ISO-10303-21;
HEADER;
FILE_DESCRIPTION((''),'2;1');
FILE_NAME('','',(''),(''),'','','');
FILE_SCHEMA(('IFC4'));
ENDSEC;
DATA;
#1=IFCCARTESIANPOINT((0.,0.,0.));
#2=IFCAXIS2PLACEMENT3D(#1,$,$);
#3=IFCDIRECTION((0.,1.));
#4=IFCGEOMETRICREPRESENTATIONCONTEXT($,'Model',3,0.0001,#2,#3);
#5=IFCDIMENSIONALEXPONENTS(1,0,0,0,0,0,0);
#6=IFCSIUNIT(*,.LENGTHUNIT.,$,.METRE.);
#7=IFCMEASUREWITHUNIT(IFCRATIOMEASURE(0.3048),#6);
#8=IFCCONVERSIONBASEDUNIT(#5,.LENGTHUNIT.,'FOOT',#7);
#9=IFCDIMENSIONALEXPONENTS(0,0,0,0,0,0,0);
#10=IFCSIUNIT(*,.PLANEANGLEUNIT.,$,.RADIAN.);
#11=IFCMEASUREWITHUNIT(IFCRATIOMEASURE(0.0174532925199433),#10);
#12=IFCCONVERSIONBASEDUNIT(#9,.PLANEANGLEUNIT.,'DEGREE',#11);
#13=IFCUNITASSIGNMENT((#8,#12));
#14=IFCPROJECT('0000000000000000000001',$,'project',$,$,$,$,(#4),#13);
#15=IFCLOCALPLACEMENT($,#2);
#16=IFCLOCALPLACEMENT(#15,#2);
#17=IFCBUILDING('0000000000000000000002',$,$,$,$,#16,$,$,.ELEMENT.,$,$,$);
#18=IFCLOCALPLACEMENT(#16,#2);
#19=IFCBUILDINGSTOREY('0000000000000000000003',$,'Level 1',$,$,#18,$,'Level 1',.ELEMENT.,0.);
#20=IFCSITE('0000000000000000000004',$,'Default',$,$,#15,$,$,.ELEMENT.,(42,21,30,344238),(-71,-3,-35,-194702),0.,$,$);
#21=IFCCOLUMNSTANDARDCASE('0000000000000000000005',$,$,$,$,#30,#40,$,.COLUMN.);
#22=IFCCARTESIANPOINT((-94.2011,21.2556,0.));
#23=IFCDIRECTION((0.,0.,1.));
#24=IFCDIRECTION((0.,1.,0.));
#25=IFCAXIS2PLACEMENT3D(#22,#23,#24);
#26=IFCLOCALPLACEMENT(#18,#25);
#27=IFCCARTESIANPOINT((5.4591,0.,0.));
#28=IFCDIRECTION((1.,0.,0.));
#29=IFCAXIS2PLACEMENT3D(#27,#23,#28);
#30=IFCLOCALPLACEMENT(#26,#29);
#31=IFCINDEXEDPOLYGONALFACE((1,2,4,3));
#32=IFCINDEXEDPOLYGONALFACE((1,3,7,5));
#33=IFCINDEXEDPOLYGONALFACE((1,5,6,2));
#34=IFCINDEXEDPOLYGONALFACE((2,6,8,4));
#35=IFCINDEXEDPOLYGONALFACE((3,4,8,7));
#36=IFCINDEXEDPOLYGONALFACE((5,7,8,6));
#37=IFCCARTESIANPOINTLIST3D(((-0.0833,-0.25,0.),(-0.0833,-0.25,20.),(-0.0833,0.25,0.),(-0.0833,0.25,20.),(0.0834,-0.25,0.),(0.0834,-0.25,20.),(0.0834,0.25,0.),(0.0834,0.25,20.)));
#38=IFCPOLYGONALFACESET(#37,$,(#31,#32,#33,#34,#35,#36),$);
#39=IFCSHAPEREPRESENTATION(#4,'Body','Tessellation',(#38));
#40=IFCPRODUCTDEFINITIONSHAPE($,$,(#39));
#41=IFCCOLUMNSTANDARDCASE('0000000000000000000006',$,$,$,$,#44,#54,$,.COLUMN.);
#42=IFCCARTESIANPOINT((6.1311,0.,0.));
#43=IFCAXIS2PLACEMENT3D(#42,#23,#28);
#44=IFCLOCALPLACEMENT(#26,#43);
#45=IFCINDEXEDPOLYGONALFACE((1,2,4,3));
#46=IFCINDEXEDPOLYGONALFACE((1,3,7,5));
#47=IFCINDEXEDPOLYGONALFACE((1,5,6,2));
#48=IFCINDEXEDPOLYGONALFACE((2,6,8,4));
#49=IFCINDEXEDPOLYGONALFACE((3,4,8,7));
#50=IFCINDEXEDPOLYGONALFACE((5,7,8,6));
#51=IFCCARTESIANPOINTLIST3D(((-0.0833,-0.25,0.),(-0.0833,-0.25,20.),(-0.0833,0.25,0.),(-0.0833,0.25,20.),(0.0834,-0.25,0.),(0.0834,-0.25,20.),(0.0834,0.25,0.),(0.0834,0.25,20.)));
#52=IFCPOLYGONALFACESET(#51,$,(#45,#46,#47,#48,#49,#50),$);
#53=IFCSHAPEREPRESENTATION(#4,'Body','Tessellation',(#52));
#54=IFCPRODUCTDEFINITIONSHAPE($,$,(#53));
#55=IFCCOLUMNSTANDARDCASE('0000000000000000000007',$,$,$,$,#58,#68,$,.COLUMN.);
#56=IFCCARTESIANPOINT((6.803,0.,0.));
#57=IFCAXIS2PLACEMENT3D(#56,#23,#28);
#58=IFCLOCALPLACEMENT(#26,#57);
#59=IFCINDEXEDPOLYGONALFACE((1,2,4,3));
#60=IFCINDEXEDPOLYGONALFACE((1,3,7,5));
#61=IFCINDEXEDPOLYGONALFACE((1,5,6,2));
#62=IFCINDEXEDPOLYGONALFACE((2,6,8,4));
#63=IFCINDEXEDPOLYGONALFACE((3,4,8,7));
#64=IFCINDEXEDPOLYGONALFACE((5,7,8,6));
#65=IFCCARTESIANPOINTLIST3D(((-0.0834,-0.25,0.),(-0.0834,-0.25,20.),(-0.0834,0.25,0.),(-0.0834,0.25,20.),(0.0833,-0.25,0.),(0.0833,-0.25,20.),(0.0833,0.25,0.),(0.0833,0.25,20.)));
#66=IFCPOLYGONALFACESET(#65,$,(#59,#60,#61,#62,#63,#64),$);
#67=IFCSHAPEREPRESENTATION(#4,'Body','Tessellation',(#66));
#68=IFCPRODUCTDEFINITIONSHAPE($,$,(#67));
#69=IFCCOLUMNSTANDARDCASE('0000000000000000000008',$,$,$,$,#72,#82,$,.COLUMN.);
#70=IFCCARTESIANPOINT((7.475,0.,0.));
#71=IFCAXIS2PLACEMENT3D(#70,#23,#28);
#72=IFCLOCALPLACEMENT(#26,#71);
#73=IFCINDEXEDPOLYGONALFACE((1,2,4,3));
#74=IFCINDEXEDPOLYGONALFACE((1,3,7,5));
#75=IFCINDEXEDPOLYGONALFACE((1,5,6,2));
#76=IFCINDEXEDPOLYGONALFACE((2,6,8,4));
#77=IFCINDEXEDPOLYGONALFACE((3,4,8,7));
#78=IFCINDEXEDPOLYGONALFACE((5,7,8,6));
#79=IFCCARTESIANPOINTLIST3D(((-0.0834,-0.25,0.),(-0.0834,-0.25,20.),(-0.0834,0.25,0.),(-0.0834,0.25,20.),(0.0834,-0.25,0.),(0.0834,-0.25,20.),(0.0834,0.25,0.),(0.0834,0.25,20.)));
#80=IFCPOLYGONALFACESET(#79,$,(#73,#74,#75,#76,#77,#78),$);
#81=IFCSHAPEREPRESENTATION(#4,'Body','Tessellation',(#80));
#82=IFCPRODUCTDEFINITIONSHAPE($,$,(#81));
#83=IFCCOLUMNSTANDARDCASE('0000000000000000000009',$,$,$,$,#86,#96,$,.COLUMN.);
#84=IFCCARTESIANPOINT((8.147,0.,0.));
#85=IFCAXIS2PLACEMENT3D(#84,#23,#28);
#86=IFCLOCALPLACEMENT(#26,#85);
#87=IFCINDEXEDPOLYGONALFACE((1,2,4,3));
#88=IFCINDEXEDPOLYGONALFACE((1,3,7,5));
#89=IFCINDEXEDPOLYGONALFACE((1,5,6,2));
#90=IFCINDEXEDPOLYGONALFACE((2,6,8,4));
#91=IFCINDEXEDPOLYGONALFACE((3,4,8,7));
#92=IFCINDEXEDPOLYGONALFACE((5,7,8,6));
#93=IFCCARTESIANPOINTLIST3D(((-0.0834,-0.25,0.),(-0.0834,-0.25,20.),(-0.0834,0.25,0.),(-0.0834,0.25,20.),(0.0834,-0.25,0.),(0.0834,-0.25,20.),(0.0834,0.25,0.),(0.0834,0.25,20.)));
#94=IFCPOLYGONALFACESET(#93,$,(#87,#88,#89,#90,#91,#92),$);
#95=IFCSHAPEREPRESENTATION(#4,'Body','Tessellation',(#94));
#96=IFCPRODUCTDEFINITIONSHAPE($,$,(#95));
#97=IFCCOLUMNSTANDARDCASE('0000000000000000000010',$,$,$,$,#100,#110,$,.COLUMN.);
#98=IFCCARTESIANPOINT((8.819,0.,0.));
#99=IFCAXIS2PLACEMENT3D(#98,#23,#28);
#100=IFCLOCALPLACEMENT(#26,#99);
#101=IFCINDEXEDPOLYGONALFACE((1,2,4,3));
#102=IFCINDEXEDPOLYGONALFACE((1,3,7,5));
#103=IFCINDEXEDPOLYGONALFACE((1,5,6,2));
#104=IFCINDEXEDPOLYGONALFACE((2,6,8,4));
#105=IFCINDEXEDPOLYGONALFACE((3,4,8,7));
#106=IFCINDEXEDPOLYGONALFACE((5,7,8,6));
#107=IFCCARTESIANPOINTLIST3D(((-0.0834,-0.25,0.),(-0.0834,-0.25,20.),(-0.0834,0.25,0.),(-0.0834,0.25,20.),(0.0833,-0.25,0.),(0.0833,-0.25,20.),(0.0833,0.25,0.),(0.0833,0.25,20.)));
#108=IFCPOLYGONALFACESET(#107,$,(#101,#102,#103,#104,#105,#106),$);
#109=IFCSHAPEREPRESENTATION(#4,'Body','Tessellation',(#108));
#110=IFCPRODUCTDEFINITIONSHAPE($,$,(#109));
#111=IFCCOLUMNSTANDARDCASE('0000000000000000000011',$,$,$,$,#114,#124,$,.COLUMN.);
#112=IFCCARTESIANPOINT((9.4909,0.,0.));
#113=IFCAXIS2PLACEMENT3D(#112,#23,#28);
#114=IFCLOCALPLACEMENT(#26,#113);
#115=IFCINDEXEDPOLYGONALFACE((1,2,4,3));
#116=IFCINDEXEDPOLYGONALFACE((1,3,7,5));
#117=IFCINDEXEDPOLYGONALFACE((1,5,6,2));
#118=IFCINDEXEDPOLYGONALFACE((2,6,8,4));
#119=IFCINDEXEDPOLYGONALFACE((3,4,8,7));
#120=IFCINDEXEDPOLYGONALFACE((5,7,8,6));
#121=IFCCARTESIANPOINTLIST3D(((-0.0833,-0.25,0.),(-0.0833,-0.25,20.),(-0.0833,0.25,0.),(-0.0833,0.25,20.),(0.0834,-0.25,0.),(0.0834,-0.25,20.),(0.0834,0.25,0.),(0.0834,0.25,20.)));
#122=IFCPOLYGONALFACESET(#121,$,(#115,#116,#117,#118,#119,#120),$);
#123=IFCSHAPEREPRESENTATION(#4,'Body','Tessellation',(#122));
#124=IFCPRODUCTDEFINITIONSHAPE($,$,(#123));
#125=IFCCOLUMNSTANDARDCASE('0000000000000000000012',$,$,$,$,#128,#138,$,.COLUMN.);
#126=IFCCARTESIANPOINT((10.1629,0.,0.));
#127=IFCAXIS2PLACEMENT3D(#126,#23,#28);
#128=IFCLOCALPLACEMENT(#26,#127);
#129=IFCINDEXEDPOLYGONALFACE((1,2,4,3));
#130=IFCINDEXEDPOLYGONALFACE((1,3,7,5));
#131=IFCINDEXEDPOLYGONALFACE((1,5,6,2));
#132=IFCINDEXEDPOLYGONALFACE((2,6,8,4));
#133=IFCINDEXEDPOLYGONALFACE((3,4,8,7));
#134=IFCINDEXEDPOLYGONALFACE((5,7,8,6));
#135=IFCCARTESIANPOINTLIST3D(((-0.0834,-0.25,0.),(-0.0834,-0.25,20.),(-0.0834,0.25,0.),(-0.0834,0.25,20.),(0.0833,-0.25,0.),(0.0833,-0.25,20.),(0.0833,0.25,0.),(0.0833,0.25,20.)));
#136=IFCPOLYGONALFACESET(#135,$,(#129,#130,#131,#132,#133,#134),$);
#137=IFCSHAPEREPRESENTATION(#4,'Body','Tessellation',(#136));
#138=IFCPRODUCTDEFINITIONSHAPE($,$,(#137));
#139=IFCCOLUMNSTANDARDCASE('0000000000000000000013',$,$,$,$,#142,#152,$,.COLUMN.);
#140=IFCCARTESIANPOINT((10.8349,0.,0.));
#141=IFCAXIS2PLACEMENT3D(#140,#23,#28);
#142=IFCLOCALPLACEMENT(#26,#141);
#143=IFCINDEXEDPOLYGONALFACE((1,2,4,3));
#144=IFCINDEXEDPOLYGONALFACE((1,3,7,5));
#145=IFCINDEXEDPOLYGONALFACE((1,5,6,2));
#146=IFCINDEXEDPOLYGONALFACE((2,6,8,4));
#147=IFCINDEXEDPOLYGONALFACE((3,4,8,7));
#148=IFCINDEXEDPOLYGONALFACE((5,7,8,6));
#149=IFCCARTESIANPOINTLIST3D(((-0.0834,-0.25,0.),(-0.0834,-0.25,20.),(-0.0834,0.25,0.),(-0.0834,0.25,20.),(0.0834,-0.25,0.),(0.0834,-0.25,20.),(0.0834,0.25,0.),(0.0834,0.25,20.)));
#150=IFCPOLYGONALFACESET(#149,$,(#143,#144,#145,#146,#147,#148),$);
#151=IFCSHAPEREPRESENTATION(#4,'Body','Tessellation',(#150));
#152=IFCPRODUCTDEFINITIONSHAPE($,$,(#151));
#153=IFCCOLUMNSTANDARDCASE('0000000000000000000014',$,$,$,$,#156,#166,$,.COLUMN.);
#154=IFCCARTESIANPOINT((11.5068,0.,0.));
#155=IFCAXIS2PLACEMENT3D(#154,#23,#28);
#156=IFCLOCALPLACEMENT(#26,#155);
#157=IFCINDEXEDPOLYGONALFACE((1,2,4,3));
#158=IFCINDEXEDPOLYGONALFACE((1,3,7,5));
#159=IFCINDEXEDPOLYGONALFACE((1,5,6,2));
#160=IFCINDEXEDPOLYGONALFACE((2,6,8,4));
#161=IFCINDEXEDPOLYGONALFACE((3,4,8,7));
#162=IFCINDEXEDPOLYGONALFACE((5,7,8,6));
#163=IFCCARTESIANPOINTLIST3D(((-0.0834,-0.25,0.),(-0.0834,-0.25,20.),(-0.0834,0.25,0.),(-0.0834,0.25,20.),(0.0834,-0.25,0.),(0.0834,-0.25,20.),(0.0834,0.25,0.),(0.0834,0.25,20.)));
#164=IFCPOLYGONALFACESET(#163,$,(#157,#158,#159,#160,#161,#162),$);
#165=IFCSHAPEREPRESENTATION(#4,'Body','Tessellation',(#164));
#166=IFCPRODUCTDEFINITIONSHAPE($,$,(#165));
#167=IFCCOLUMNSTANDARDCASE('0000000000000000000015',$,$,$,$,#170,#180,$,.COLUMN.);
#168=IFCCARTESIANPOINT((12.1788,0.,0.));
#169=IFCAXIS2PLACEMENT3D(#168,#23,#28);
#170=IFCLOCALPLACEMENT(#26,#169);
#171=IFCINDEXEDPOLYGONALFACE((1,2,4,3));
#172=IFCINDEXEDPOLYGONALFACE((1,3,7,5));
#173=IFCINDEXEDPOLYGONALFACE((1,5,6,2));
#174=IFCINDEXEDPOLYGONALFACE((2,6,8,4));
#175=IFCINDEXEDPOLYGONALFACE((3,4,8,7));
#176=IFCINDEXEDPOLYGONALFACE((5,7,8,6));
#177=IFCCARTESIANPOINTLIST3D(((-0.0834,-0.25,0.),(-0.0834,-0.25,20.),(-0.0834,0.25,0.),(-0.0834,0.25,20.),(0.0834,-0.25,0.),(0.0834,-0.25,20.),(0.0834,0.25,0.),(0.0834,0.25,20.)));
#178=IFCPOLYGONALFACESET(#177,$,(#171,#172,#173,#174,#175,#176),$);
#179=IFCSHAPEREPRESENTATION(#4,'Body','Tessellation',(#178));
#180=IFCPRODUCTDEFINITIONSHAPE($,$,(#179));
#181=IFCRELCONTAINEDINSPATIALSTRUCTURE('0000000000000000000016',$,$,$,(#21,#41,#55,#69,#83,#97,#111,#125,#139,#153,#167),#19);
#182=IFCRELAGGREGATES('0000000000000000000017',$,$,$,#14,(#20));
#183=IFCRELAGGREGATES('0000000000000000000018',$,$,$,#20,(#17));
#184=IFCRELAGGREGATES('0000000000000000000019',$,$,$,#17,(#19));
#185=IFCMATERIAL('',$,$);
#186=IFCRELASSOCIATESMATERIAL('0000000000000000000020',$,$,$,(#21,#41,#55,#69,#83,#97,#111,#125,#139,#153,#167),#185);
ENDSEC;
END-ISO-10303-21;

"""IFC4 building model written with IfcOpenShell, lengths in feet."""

from ifc_helpers import new_model, entity, si_unit, converted_unit, direction, frame, origin, place, context, project, spatial, rectangle, extrude, material, element, save


model = new_model("IFC4")

# Units and contexts
model_context = context("Model", 3, precision=0.0001, world=origin(), true_north=direction((0.0, 1.0)))
ifc_project = project(units=[converted_unit("LENGTHUNIT", "FOOT", entity("IfcRatioMeasure", 0.3048), si_unit("LENGTHUNIT", "METRE"), dimensions=[1, 0, 0, 0, 0, 0, 0]), converted_unit("PLANEANGLEUNIT", "DEGREE", entity("IfcRatioMeasure", 0.0174532925199433), si_unit("PLANEANGLEUNIT", "RADIAN"), dimensions=[0, 0, 0, 0, 0, 0, 0])], contexts=[model_context])

# Site, building, storey
site_placement = place(None, origin())
site = spatial("IfcSite", under=ifc_project, at=site_placement, Name="Default", CompositionType="ELEMENT", RefLatitude=(42, 21, 30, 344238), RefLongitude=(-71, -3, -35, -194702), RefElevation=0.0)
building_placement = place(site_placement, origin())
building = spatial("IfcBuilding", under=site, at=building_placement, CompositionType="ELEMENT")
storey_placement = place(building_placement, origin())
storey = spatial("IfcBuildingStorey", under=building, at=storey_placement, Name="Level 1", LongName="Level 1", CompositionType="ELEMENT", Elevation=0.0)

# Columns
ifc_material_1 = material(Name="")
placement_1 = place(storey_placement, frame((-94.2011, 21.2556, 0.0), z_axis=(0.0, 0.0, 1.0), x_axis=(0.0, 1.0, 0.0)))
for number, where, z_axis, x_axis in (
    (1, (5.4591, 0.0, 0.0), (0.0, 0.0, 1.0), (1.0, 0.0, 0.0)),
    (2, (6.1311, 0.0, 0.0), (0.0, 0.0, 1.0), (1.0, 0.0, 0.0)),
    (3, (6.803, 0.0, 0.0), (0.0, 0.0, 1.0), (1.0, 0.0, 0.0)),
    (4, (7.475, 0.0, 0.0), (0.0, 0.0, 1.0), (1.0, 0.0, 0.0)),
    (5, (8.147, 0.0, 0.0), (0.0, 0.0, 1.0), (1.0, 0.0, 0.0)),
    (6, (8.819, 0.0, 0.0), (0.0, 0.0, 1.0), (1.0, 0.0, 0.0)),
    (7, (9.4909, 0.0, 0.0), (0.0, 0.0, 1.0), (1.0, 0.0, 0.0)),
    (8, (10.1629, 0.0, 0.0), (0.0, 0.0, 1.0), (1.0, 0.0, 0.0)),
    (9, (10.8349, 0.0, 0.0), (0.0, 0.0, 1.0), (1.0, 0.0, 0.0)),
    (10, (11.5068, 0.0, 0.0), (0.0, 0.0, 1.0), (1.0, 0.0, 0.0)),
    (11, (12.1788, 0.0, 0.0), (0.0, 0.0, 1.0), (1.0, 0.0, 0.0)),
):
    element("IfcColumnStandardCase", number, at=place(placement_1, frame(where, z_axis=z_axis, x_axis=x_axis)), inside=storey, material=ifc_material_1, PredefinedType="COLUMN", context=model_context, shape_type="SweptSolid", body=[
        extrude(rectangle(XDim=0.1667, YDim=0.5), origin(), (0.0, 0.0, 1.0), 20.0),
    ])

save(model, "model.ifc")
